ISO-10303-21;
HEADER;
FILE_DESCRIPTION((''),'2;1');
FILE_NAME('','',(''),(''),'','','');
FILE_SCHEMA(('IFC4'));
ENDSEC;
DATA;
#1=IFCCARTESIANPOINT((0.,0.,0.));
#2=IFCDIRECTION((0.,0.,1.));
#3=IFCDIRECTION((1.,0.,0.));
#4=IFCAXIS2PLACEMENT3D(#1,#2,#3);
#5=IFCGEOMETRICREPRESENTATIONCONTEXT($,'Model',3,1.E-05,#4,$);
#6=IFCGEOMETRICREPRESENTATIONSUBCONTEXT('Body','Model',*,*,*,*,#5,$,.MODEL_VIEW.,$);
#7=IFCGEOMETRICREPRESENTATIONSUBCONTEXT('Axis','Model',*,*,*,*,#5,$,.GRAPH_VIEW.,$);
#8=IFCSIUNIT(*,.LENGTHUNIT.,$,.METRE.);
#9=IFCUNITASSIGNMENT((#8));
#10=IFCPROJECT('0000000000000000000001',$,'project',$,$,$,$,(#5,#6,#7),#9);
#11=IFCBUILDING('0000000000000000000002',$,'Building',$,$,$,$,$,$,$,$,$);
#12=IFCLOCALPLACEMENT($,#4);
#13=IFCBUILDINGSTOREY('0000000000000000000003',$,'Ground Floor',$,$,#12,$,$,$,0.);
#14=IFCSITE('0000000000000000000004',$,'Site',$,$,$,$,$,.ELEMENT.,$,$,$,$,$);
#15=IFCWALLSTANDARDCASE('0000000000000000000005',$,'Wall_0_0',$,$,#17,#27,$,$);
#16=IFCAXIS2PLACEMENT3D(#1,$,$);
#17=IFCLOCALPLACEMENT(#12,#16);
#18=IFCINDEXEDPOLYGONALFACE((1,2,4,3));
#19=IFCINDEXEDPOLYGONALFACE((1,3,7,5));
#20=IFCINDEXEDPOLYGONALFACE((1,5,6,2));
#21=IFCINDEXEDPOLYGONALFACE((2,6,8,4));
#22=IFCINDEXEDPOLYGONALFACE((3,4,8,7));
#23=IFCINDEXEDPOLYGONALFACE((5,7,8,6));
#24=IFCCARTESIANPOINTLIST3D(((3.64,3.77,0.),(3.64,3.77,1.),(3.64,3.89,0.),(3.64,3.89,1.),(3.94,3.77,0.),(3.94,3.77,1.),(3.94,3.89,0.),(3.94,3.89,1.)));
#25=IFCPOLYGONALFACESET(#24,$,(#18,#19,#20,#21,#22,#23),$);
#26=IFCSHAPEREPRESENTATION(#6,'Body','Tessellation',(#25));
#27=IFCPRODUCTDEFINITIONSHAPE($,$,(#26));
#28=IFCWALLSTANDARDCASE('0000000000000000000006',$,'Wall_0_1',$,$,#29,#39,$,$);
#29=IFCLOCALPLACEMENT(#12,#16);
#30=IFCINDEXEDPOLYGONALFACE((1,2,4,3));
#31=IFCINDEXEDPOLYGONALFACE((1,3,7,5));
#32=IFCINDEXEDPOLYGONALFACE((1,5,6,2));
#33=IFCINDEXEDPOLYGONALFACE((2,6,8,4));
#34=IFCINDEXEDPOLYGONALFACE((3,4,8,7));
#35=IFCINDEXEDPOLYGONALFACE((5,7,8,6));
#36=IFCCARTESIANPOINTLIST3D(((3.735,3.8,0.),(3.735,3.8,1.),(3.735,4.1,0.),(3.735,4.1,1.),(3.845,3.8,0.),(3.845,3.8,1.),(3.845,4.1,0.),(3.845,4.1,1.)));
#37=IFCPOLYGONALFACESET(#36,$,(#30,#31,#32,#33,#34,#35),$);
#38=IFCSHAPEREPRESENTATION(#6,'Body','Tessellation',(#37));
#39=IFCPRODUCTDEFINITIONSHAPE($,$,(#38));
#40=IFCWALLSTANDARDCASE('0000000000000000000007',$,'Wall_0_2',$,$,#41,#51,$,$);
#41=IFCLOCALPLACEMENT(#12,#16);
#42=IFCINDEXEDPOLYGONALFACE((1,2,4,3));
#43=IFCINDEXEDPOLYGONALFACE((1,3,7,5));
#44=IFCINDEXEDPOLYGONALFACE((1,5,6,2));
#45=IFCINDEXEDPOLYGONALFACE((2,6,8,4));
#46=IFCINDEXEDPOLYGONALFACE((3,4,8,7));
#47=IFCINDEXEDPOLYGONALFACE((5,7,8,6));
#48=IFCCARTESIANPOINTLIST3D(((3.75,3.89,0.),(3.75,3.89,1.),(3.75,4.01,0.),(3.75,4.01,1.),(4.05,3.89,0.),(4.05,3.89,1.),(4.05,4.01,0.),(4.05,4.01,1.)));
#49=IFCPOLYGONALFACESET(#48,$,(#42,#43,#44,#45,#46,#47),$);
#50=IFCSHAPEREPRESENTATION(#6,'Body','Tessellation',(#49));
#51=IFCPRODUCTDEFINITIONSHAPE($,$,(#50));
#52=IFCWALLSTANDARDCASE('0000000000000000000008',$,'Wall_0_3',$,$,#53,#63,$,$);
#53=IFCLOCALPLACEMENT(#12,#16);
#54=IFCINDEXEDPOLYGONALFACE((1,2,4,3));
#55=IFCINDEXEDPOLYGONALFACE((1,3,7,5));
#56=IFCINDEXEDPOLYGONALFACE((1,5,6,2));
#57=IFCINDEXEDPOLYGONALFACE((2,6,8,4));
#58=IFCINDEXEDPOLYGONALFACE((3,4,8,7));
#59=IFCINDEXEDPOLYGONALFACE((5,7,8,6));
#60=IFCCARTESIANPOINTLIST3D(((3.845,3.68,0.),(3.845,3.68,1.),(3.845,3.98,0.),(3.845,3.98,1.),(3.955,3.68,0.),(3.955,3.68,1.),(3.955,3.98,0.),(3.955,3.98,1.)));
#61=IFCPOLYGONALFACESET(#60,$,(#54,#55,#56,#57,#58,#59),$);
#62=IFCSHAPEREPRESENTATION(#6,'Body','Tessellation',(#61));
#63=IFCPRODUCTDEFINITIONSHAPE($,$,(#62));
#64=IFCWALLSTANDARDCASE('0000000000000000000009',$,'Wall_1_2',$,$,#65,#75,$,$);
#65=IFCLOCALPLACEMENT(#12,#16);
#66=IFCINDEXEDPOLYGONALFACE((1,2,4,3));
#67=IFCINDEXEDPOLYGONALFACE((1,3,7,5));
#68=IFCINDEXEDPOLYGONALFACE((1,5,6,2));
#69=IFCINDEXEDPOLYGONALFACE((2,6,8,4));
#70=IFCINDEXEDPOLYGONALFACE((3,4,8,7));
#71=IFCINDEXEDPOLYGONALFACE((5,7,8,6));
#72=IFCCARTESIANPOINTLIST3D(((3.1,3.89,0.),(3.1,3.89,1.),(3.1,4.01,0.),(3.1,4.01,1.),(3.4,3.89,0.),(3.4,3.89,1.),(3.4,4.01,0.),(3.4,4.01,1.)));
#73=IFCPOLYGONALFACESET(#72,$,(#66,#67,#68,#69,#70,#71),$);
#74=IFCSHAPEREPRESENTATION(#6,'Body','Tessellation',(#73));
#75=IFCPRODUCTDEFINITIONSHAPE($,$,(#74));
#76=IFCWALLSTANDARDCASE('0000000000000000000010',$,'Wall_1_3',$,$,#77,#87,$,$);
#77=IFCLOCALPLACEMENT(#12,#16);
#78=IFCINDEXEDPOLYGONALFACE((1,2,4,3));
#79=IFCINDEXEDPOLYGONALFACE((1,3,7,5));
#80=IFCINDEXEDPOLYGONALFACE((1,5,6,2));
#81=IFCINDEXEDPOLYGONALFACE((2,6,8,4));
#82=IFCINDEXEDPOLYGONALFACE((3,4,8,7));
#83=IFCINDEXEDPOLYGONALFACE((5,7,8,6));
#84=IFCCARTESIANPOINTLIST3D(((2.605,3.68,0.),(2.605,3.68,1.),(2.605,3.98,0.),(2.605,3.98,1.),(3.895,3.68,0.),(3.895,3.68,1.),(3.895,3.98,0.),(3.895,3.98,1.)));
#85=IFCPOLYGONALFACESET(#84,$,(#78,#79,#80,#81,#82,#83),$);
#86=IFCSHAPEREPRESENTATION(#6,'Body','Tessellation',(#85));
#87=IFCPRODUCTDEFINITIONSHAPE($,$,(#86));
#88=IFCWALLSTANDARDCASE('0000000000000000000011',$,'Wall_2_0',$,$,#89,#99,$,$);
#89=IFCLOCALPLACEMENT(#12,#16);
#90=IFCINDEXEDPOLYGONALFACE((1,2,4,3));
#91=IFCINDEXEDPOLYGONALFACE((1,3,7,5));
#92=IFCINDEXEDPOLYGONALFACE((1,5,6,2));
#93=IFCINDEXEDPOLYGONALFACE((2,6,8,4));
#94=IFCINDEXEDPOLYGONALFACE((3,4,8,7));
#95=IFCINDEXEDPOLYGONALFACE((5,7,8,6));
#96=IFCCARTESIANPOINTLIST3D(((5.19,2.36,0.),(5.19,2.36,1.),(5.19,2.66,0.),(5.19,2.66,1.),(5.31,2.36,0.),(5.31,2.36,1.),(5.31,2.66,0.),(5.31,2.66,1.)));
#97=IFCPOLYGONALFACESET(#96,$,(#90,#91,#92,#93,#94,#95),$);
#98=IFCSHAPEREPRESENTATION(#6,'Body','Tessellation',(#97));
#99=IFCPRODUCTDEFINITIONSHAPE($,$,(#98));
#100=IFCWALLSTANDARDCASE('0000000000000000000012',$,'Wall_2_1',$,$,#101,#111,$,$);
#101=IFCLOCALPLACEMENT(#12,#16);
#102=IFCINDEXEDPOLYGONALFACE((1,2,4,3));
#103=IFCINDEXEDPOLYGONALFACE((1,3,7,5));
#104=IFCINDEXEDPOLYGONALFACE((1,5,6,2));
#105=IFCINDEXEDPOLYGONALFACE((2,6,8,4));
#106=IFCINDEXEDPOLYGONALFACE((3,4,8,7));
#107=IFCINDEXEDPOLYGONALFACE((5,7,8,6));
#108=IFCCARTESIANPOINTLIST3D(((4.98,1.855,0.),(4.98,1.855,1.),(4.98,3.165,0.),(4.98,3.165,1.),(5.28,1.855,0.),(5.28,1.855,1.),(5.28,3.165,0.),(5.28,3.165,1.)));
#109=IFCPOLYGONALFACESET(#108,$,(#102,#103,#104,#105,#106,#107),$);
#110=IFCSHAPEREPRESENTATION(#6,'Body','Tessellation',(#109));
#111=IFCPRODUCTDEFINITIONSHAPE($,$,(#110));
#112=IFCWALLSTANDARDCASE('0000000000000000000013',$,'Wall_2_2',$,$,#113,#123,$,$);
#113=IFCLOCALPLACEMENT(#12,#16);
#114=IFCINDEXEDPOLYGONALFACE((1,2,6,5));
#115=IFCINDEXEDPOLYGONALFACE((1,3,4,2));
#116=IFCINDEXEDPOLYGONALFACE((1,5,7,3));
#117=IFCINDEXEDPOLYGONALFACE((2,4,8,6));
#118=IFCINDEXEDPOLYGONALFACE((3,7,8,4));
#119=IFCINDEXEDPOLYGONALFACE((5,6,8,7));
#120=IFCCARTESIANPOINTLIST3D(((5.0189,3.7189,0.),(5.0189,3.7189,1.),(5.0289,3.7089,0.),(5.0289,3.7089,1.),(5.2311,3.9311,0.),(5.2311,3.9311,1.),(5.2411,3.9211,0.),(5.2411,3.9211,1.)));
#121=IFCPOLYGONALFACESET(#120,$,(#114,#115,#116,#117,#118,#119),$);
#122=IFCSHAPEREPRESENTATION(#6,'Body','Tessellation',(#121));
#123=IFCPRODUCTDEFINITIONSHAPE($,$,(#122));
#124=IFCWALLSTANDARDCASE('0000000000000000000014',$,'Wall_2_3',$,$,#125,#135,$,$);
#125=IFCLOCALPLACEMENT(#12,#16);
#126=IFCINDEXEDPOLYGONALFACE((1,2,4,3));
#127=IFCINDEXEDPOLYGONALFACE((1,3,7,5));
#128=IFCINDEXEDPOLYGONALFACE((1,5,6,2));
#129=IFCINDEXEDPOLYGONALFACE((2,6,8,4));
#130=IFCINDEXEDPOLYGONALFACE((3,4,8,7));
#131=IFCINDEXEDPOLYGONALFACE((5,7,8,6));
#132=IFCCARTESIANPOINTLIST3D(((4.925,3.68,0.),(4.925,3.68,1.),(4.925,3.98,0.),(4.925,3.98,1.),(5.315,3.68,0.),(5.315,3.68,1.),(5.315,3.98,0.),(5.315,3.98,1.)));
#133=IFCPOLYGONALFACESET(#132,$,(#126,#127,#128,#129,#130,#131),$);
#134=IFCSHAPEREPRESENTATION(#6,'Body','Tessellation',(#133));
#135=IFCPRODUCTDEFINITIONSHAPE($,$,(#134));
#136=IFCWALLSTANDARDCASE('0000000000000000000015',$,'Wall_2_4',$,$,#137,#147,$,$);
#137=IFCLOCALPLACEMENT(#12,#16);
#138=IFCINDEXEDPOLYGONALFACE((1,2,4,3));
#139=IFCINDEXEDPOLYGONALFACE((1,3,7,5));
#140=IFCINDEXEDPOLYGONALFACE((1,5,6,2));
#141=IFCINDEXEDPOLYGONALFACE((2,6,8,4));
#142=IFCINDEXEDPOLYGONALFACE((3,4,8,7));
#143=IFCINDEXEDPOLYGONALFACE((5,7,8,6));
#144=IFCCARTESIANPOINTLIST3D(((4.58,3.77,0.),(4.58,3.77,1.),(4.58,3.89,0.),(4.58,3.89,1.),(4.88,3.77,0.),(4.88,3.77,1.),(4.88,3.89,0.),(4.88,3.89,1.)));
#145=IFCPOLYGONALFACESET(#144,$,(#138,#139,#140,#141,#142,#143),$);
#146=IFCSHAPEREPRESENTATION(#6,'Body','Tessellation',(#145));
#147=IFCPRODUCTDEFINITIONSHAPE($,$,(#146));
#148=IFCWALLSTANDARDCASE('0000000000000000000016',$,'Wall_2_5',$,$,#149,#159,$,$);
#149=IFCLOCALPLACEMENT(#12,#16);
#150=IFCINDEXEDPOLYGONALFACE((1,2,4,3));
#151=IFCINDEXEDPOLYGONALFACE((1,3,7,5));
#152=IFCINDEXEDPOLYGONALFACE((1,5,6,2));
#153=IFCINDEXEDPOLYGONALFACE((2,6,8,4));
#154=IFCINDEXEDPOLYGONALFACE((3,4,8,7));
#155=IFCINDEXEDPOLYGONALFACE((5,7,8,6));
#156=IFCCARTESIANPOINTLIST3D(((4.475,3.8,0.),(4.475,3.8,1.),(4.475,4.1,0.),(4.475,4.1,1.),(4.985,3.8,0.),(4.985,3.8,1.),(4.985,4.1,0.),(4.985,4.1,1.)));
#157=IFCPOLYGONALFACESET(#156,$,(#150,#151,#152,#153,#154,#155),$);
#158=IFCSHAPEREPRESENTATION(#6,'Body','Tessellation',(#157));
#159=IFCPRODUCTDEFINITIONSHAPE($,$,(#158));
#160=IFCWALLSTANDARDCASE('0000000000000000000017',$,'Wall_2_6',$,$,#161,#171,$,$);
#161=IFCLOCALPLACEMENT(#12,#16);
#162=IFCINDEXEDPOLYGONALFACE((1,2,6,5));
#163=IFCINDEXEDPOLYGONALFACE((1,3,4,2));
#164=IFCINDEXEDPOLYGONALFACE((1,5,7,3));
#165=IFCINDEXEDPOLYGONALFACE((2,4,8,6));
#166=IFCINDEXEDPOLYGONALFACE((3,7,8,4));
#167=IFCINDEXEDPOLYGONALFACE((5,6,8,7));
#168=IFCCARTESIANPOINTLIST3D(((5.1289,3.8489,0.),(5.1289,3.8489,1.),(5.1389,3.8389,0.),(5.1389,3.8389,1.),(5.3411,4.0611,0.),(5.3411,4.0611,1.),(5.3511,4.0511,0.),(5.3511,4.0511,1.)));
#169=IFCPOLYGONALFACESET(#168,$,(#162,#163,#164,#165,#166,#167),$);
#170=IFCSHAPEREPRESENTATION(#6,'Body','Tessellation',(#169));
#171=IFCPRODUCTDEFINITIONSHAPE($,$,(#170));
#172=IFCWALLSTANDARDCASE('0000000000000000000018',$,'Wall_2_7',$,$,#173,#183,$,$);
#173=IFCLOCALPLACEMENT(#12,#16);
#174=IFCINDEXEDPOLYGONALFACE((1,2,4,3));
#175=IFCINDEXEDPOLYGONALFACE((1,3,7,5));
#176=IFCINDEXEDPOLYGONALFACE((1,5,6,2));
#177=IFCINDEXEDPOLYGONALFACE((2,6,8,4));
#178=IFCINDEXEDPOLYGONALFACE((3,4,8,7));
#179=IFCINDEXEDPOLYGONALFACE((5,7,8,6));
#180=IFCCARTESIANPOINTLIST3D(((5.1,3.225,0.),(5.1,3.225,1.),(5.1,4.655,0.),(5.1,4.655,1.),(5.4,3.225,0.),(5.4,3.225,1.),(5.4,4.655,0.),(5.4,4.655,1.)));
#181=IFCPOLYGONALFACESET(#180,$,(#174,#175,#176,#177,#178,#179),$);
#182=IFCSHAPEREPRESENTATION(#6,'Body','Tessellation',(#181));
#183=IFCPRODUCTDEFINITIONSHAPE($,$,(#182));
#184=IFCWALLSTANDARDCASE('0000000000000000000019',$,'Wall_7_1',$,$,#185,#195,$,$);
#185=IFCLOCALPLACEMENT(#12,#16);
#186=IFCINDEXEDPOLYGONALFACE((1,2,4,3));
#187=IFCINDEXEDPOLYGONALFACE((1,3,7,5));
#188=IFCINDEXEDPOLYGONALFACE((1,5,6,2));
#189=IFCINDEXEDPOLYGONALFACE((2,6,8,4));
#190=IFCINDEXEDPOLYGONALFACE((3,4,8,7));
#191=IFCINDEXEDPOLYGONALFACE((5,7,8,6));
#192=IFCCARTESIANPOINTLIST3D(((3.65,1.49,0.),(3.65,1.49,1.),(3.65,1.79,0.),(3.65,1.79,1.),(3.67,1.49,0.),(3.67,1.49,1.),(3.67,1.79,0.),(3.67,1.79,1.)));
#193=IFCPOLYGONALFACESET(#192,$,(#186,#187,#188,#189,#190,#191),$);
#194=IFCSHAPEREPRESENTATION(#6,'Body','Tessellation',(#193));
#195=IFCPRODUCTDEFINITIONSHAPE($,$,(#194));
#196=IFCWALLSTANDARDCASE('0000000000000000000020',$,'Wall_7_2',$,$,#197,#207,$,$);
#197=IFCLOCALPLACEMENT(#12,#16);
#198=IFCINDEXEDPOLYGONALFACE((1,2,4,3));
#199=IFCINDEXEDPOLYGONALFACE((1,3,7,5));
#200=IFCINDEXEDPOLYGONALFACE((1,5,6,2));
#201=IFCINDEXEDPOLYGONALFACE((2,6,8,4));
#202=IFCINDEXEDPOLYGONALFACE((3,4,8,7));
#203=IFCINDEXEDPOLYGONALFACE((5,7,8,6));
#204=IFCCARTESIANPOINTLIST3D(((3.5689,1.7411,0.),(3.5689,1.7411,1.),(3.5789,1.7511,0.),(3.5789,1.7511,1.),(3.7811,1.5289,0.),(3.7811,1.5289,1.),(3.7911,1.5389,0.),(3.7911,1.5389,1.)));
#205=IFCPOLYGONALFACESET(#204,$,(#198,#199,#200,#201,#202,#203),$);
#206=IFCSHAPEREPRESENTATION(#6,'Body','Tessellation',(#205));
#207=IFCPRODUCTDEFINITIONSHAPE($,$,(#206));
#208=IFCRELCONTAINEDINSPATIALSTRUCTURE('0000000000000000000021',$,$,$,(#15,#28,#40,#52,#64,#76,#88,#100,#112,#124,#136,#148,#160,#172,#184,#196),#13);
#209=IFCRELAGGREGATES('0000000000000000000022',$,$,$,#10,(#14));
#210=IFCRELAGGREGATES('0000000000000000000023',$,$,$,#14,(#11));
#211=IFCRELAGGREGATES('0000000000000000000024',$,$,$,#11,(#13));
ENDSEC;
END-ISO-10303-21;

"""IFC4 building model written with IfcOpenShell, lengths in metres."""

from ifc_helpers import new_model, si_unit, frame, origin_with_axes, origin_2d, place, context, subcontext, project, spatial, rectangle, extrude, element, save


model = new_model("IFC4")

# Units and contexts
model_context = context("Model", 3, precision=1e-05, world=origin_with_axes())
body_context = subcontext(model_context, "Body", "Model", "MODEL_VIEW")
axis_context = subcontext(model_context, "Axis", "Model", "GRAPH_VIEW")
ifc_project = project(units=[si_unit("LENGTHUNIT", "METRE")], contexts=[model_context, body_context, axis_context])

# Site, building, storey
site = spatial("IfcSite", under=ifc_project, Name="Site", CompositionType="ELEMENT")
building = spatial("IfcBuilding", under=site, Name="Building")
storey_placement = place(None, origin_with_axes())
storey = spatial("IfcBuildingStorey", under=building, at=storey_placement, Name="Ground Floor", Elevation=0.0)

# Walls
wall_1_placement = place(storey_placement, frame((3.79, 3.83, 0.0), z_axis=(0.0, 0.0, 1.0), x_axis=(0.0, 1.0, 0.0)))
element("IfcWallStandardCase", 1, at=wall_1_placement, inside=storey, Name="Wall_0_0", context=body_context, shape_type="SweptSolid", body=[
    extrude(rectangle(XDim=0.12, YDim=0.3, at=origin_2d()), origin_with_axes(), (0.0, 0.0, 1.0), 1.0),
])
wall_2_placement = place(storey_placement, frame((3.79, 3.95, 0.0), z_axis=(0.0, 0.0, 1.0), x_axis=(1.0, 0.0, 0.0)))
element("IfcWallStandardCase", 2, at=wall_2_placement, inside=storey, Name="Wall_0_1", context=body_context, shape_type="SweptSolid", body=[
    extrude(rectangle(XDim=0.11, YDim=0.3, at=origin_2d()), origin_with_axes(), (0.0, 0.0, 1.0), 1.0),
])
wall_3_placement = place(storey_placement, frame((3.9, 3.95, 0.0), z_axis=(0.0, 0.0, 1.0), x_axis=(0.0, -1.0, 0.0)))
element("IfcWallStandardCase", 3, at=wall_3_placement, inside=storey, Name="Wall_0_2", context=body_context, shape_type="SweptSolid", body=[
    extrude(rectangle(XDim=0.12, YDim=0.3, at=origin_2d()), origin_with_axes(), (0.0, 0.0, 1.0), 1.0),
])
wall_4_placement = place(storey_placement, frame((3.9, 3.83, 0.0), z_axis=(0.0, 0.0, 1.0), x_axis=(-1.0, 0.0, 0.0)))
element("IfcWallStandardCase", 4, at=wall_4_placement, inside=storey, Name="Wall_0_3", context=body_context, shape_type="SweptSolid", body=[
    extrude(rectangle(XDim=0.11, YDim=0.3, at=origin_2d()), origin_with_axes(), (0.0, 0.0, 1.0), 1.0),
])
wall_5_placement = place(storey_placement, frame((3.25, 3.95, 0.0), z_axis=(0.0, 0.0, 1.0), x_axis=(0.0, -1.0, 0.0)))
element("IfcWallStandardCase", 5, at=wall_5_placement, inside=storey, Name="Wall_1_2", context=body_context, shape_type="SweptSolid", body=[
    extrude(rectangle(XDim=0.12, YDim=0.3, at=origin_2d()), origin_with_axes(), (0.0, 0.0, 1.0), 1.0),
])
wall_6_placement = place(storey_placement, frame((3.25, 3.83, 0.0), z_axis=(0.0, 0.0, 1.0), x_axis=(-1.0, 0.0, 0.0)))
element("IfcWallStandardCase", 6, at=wall_6_placement, inside=storey, Name="Wall_1_3", context=body_context, shape_type="SweptSolid", body=[
    extrude(rectangle(XDim=1.29, YDim=0.3, at=origin_2d()), origin_with_axes(), (0.0, 0.0, 1.0), 1.0),
])
wall_7_placement = place(storey_placement, frame((5.25, 2.51, 0.0), z_axis=(0.0, 0.0, 1.0), x_axis=(-1.0, 0.0, 0.0)))
element("IfcWallStandardCase", 7, at=wall_7_placement, inside=storey, Name="Wall_2_0", context=body_context, shape_type="SweptSolid", body=[
    extrude(rectangle(XDim=0.12, YDim=0.3, at=origin_2d()), origin_with_axes(), (0.0, 0.0, 1.0), 1.0),
])
wall_8_placement = place(storey_placement, frame((5.13, 2.51, 0.0), z_axis=(0.0, 0.0, 1.0), x_axis=(0.0, 1.0, 0.0)))
element("IfcWallStandardCase", 8, at=wall_8_placement, inside=storey, Name="Wall_2_1", context=body_context, shape_type="SweptSolid", body=[
    extrude(rectangle(XDim=1.31, YDim=0.3, at=origin_2d()), origin_with_axes(), (0.0, 0.0, 1.0), 1.0),
])
wall_9_placement = place(storey_placement, frame((5.13, 3.82, 0.0), z_axis=(0.0, 0.0, 1.0), x_axis=(-0.707107, 0.707107, 0.0)))
element("IfcWallStandardCase", 9, at=wall_9_placement, inside=storey, Name="Wall_2_2", context=body_context, shape_type="SweptSolid", body=[
    extrude(rectangle(XDim=0.0141, YDim=0.3, at=origin_2d()), origin_with_axes(), (0.0, 0.0, 1.0), 1.0),
])
wall_10_placement = place(storey_placement, frame((5.12, 3.83, 0.0), z_axis=(0.0, 0.0, 1.0), x_axis=(-1.0, 0.0, 0.0)))
element("IfcWallStandardCase", 10, at=wall_10_placement, inside=storey, Name="Wall_2_3", context=body_context, shape_type="SweptSolid", body=[
    extrude(rectangle(XDim=0.39, YDim=0.3, at=origin_2d()), origin_with_axes(), (0.0, 0.0, 1.0), 1.0),
])
wall_11_placement = place(storey_placement, frame((4.73, 3.83, 0.0), z_axis=(0.0, 0.0, 1.0), x_axis=(0.0, 1.0, 0.0)))
element("IfcWallStandardCase", 11, at=wall_11_placement, inside=storey, Name="Wall_2_4", context=body_context, shape_type="SweptSolid", body=[
    extrude(rectangle(XDim=0.12, YDim=0.3, at=origin_2d()), origin_with_axes(), (0.0, 0.0, 1.0), 1.0),
])
wall_12_placement = place(storey_placement, frame((4.73, 3.95, 0.0), z_axis=(0.0, 0.0, 1.0), x_axis=(1.0, 0.0, 0.0)))
element("IfcWallStandardCase", 12, at=wall_12_placement, inside=storey, Name="Wall_2_5", context=body_context, shape_type="SweptSolid", body=[
    extrude(rectangle(XDim=0.51, YDim=0.3, at=origin_2d()), origin_with_axes(), (0.0, 0.0, 1.0), 1.0),
])
wall_13_placement = place(storey_placement, frame((5.24, 3.95, 0.0), z_axis=(0.0, 0.0, 1.0), x_axis=(0.707107, -0.707107, 0.0)))
element("IfcWallStandardCase", 13, at=wall_13_placement, inside=storey, Name="Wall_2_6", context=body_context, shape_type="SweptSolid", body=[
    extrude(rectangle(XDim=0.0141, YDim=0.3, at=origin_2d()), origin_with_axes(), (0.0, 0.0, 1.0), 1.0),
])
wall_14_placement = place(storey_placement, frame((5.25, 3.94, 0.0), z_axis=(0.0, 0.0, 1.0), x_axis=(0.0, -1.0, 0.0)))
element("IfcWallStandardCase", 14, at=wall_14_placement, inside=storey, Name="Wall_2_7", context=body_context, shape_type="SweptSolid", body=[
    extrude(rectangle(XDim=1.43, YDim=0.3, at=origin_2d()), origin_with_axes(), (0.0, 0.0, 1.0), 1.0),
])
wall_15_placement = place(storey_placement, frame((3.66, 1.64, 0.0), z_axis=(0.0, 0.0, 1.0), x_axis=(1.0, 0.0, 0.0)))
element("IfcWallStandardCase", 15, at=wall_15_placement, inside=storey, Name="Wall_7_1", context=body_context, shape_type="SweptSolid", body=[
    extrude(rectangle(XDim=0.02, YDim=0.3, at=origin_2d()), origin_with_axes(), (0.0, 0.0, 1.0), 1.0),
])
wall_16_placement = place(storey_placement, frame((3.68, 1.64, 0.0), z_axis=(0.0, 0.0, 1.0), x_axis=(0.707107, 0.707107, 0.0)))
element("IfcWallStandardCase", 16, at=wall_16_placement, inside=storey, Name="Wall_7_2", context=body_context, shape_type="SweptSolid", body=[
    extrude(rectangle(XDim=0.0141, YDim=0.3, at=origin_2d()), origin_with_axes(), (0.0, 0.0, 1.0), 1.0),
])

save(model, "model.ifc")
